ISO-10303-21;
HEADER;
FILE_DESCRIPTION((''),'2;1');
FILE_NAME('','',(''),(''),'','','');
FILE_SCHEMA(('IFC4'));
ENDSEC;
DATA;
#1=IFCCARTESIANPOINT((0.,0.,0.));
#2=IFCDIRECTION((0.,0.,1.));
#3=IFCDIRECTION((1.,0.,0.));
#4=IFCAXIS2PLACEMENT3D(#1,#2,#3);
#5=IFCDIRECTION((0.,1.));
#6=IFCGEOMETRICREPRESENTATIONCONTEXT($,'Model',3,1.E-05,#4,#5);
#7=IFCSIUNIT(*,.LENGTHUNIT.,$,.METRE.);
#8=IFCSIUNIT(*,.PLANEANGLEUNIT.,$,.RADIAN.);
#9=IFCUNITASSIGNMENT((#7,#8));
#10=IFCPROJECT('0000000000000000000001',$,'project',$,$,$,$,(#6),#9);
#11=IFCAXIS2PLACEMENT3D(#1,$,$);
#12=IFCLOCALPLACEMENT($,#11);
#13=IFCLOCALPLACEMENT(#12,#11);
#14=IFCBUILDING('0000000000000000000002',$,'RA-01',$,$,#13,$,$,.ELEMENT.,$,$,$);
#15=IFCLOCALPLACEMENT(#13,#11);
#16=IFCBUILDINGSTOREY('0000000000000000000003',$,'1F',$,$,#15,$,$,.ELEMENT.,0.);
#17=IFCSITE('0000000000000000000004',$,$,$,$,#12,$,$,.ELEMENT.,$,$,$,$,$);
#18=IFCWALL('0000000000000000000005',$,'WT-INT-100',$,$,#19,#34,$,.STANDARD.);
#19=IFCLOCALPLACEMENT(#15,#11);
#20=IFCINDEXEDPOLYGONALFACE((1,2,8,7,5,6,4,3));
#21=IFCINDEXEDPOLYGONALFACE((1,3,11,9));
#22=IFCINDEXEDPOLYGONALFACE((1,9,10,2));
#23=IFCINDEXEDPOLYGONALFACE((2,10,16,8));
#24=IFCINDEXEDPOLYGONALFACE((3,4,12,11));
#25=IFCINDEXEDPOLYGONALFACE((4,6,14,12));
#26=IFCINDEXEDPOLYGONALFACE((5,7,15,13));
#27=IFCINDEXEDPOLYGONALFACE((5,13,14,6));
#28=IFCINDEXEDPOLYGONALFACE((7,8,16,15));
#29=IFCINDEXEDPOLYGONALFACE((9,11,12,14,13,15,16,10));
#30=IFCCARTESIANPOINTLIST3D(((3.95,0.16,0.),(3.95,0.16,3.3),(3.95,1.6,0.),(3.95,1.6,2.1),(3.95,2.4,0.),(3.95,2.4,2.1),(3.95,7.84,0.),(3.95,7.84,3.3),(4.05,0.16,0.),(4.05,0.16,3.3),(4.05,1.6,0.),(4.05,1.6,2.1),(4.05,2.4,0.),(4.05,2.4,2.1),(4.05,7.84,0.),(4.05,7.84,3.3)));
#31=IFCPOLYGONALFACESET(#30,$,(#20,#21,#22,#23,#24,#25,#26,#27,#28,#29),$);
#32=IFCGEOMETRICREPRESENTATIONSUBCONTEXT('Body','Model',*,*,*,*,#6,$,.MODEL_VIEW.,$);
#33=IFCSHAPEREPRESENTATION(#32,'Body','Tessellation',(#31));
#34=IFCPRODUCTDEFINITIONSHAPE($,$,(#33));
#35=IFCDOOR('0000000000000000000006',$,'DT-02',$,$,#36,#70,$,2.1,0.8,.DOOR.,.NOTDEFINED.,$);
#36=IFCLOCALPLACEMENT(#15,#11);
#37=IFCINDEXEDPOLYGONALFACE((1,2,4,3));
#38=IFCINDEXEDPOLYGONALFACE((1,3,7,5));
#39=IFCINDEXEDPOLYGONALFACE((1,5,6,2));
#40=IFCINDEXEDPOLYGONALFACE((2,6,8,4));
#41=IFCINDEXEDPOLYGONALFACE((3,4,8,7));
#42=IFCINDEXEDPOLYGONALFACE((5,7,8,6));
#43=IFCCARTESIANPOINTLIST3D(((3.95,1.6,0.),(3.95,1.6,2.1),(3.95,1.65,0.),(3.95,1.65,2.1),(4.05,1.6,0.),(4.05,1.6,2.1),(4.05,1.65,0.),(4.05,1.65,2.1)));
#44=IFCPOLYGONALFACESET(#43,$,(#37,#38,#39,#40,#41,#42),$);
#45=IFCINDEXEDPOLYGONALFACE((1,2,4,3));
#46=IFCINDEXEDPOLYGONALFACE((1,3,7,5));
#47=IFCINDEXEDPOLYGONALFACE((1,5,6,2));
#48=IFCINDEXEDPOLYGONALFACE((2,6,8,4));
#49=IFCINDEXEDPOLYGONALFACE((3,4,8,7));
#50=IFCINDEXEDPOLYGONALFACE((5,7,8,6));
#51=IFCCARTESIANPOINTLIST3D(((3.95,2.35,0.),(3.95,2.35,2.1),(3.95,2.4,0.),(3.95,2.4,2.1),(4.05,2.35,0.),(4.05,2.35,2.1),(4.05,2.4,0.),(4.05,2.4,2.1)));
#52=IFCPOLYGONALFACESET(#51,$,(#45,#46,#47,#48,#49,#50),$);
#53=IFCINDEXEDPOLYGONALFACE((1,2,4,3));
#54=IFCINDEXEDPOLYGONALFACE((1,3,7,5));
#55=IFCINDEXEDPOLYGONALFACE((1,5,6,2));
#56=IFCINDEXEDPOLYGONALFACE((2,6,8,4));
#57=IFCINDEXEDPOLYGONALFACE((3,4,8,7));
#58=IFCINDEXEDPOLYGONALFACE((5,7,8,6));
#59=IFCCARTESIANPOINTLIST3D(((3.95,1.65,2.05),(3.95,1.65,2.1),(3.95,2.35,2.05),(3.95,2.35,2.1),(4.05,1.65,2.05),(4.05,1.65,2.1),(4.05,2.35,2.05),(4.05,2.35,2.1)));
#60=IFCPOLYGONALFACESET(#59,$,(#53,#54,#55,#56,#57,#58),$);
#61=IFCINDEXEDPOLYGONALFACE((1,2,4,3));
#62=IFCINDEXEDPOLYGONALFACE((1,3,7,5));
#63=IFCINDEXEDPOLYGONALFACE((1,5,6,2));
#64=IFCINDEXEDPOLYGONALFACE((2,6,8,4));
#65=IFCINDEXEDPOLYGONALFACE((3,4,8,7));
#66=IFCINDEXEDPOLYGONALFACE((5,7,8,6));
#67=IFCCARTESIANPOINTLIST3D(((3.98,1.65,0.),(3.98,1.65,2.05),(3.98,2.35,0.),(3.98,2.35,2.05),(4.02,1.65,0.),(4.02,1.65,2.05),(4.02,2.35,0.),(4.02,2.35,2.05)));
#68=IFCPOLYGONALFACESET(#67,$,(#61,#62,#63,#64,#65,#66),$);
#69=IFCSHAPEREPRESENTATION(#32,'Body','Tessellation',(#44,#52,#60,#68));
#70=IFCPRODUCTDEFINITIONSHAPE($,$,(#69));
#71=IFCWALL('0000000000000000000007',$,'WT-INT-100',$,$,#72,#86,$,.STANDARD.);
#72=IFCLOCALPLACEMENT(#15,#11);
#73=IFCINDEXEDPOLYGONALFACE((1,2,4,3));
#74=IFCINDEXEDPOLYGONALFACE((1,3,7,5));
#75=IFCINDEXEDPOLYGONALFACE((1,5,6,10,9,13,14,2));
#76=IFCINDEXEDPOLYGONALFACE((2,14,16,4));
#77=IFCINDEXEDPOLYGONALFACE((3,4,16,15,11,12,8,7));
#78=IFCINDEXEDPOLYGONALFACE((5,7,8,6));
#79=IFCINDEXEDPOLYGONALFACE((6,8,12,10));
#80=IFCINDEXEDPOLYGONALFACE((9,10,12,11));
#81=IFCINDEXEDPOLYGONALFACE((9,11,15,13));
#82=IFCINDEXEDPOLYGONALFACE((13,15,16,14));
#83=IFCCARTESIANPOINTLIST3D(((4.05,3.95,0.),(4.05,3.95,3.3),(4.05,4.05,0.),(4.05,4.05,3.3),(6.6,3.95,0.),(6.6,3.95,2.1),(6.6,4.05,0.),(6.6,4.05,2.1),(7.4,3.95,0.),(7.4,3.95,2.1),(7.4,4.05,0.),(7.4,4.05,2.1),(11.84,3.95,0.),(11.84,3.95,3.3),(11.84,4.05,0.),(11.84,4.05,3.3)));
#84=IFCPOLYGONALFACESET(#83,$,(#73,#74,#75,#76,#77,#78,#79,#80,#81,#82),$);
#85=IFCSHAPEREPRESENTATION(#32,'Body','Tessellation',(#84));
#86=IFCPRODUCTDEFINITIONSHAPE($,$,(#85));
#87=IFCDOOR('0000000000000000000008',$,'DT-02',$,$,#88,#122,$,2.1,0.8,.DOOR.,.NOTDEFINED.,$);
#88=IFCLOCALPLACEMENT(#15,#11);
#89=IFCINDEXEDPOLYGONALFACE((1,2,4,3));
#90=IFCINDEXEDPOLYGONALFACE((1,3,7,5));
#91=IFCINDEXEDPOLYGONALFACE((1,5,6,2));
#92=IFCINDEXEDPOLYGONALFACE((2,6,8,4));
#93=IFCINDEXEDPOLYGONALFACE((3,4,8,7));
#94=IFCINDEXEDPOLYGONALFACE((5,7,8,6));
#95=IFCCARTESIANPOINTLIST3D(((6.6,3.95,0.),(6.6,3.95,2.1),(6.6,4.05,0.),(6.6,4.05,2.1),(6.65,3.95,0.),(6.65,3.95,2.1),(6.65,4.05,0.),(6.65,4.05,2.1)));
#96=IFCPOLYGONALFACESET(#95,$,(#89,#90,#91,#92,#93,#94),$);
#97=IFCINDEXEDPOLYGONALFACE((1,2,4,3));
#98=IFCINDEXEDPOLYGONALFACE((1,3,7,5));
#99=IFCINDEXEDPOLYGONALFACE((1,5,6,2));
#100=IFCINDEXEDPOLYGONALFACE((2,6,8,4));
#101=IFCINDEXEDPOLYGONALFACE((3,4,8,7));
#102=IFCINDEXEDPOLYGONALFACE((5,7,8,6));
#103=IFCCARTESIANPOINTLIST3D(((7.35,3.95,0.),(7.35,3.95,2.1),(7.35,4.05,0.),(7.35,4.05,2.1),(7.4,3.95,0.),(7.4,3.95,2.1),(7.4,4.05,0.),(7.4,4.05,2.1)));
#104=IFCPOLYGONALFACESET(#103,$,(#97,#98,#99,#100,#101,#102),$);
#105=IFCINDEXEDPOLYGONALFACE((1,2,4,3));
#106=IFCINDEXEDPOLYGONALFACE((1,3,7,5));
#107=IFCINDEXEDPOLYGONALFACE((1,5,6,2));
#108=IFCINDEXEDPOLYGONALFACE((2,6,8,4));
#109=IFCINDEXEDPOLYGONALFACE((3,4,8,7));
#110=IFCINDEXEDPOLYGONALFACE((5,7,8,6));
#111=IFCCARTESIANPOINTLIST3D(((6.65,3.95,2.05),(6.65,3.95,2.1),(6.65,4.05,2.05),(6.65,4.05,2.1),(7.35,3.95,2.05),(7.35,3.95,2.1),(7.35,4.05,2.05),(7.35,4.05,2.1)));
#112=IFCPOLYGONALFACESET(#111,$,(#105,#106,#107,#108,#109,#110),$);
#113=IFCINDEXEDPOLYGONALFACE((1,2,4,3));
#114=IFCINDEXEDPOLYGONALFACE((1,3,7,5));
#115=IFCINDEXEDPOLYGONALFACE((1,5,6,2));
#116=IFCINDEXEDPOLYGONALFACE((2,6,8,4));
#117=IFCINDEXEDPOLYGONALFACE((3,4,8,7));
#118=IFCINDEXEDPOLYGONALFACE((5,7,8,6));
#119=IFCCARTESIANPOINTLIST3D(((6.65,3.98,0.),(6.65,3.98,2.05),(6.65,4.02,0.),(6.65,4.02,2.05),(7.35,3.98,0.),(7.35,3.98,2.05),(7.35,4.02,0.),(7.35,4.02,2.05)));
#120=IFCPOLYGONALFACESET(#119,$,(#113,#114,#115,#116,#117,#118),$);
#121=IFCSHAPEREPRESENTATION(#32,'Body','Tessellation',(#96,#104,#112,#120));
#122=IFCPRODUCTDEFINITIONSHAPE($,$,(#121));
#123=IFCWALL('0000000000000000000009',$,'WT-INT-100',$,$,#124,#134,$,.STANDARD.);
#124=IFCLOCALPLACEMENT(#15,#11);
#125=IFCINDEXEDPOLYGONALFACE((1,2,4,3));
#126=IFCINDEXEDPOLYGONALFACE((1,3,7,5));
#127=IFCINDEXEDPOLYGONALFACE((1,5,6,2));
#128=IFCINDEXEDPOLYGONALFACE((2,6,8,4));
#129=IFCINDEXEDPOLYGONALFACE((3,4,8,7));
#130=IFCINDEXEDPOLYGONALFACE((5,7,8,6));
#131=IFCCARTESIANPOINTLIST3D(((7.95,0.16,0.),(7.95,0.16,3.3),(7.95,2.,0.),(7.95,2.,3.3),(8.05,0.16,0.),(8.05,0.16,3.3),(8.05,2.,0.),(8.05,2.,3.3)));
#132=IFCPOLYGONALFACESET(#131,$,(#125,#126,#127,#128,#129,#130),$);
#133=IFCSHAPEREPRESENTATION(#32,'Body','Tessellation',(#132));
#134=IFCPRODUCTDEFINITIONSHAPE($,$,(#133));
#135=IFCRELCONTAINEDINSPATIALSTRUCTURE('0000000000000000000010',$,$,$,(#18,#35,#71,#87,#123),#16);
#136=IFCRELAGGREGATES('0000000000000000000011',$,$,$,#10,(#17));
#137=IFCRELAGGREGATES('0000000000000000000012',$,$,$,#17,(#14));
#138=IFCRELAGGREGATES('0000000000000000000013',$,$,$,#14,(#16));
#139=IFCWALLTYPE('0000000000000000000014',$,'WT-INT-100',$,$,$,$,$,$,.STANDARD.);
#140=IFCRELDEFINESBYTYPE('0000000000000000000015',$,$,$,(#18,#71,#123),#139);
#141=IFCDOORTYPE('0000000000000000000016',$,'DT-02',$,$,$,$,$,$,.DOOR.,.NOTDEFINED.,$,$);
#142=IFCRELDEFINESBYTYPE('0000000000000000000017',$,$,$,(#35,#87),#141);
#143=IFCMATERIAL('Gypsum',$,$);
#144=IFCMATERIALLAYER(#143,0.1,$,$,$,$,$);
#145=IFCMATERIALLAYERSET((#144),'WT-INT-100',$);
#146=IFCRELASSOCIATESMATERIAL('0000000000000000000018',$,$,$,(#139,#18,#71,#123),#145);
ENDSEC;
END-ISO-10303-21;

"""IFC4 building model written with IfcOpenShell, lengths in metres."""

from ifc_helpers import new_model, si_unit, direction, frame, frame_2d, origin, origin_with_axes, place, context, subcontext, project, spatial, polyline, rectangle, outline, extrude, material, layer, layer_set, layer_usage, type_object, element, fill, save


model = new_model("IFC4")

# Units and contexts
model_context = context("Model", 3, precision=1e-05, world=origin_with_axes(), true_north=direction((0.0, 1.0)))
body_context = subcontext(model_context, "Body", "Model", "MODEL_VIEW")
ifc_project = project(units=[si_unit("LENGTHUNIT", "METRE"), si_unit("PLANEANGLEUNIT", "RADIAN")], contexts=[model_context])

# Site, building, storey
site_placement = place(None, origin())
site = spatial("IfcSite", under=ifc_project, at=site_placement, CompositionType="ELEMENT")
building_placement = place(site_placement, origin())
building = spatial("IfcBuilding", under=site, at=building_placement, Name="RA-01", CompositionType="ELEMENT")
storey_placement = place(building_placement, origin())
storey = spatial("IfcBuildingStorey", under=building, at=storey_placement, Name="1F", CompositionType="ELEMENT", Elevation=0.0)

# Walls, openings, doors
ifc_material_1 = material(Name="Gypsum")
ifc_layer_1 = layer(ifc_material_1, 0.1)
ifc_layer_set_1 = layer_set([ifc_layer_1], Name="WT-INT-100")
ifc_layer_usage_1 = layer_usage(ifc_layer_set_1, "AXIS2", "NEGATIVE", 0.05)
wall_type_1 = type_object("IfcWallType", Name="WT-INT-100", PredefinedType="STANDARD", material=ifc_layer_set_1)
wall_1_placement = place(storey_placement, frame((4.0, 0.16, 0.0), z_axis=(0.0, 0.0, 1.0), x_axis=(0.0, 1.0, 0.0)))
wall_1 = element("IfcWall", 1, at=wall_1_placement, inside=storey, type_object=wall_type_1, material=ifc_layer_usage_1, Name="WT-INT-100", PredefinedType="STANDARD", context=body_context, shape_type="SweptSolid", body=[
    extrude(outline(polyline([(0.0, -0.05), (7.68, -0.05), (7.68, 0.05), (0.0, 0.05), (0.0, -0.05)])), origin(), (0.0, 0.0, 1.0), 3.3),
])
opening_1_placement = place(wall_1_placement, frame((1.44, 0.0, 0.0)))
opening_1 = element("IfcOpeningElement", 2, at=opening_1_placement, cuts=wall_1, PredefinedType="OPENING", context=body_context, shape_type="SweptSolid", body=[
    extrude(rectangle(XDim=0.8, YDim=0.2, at=frame_2d((0.4, 0.0))), origin(), (0.0, 0.0, 1.0), 2.1),
])
door_type_1 = type_object("IfcDoorType", Name="DT-02", OperationType="NOTDEFINED", PredefinedType="DOOR")
door_1_placement = place(opening_1_placement, origin())
door_1 = element("IfcDoor", 3, at=door_1_placement, inside=storey, type_object=door_type_1, Name="DT-02", OperationType="NOTDEFINED", OverallHeight=2.1, OverallWidth=0.8, PredefinedType="DOOR", context=body_context, shape_type="SweptSolid", body=[
    extrude(outline(polyline([(0.0, -0.05), (0.05, -0.05), (0.05, 0.05), (0.0, 0.05), (0.0, -0.05)])), origin(), (0.0, 0.0, 1.0), 2.1),
    extrude(outline(polyline([(0.75, -0.05), (0.8, -0.05), (0.8, 0.05), (0.75, 0.05), (0.75, -0.05)])), origin(), (0.0, 0.0, 1.0), 2.1),
    extrude(outline(polyline([(0.05, -0.05), (0.75, -0.05), (0.75, 0.05), (0.05, 0.05), (0.05, -0.05)])), frame((0.0, 0.0, 2.05)), (0.0, 0.0, 1.0), 0.05),
    extrude(outline(polyline([(0.05, -0.02), (0.75, -0.02), (0.75, 0.02), (0.05, 0.02), (0.05, -0.02)])), origin(), (0.0, 0.0, 1.0), 2.05),
])
fill(opening_1, door_1)
wall_2_placement = place(storey_placement, frame((4.05, 4.0, 0.0)))
wall_2 = element("IfcWall", 4, at=wall_2_placement, inside=storey, type_object=wall_type_1, material=ifc_layer_usage_1, Name="WT-INT-100", PredefinedType="STANDARD", context=body_context, shape_type="SweptSolid", body=[
    extrude(outline(polyline([(0.0, -0.05), (7.79, -0.05), (7.79, 0.05), (0.0, 0.05), (0.0, -0.05)])), origin(), (0.0, 0.0, 1.0), 3.3),
])
opening_2_placement = place(wall_2_placement, frame((2.55, 0.0, 0.0)))
opening_2 = element("IfcOpeningElement", 5, at=opening_2_placement, cuts=wall_2, PredefinedType="OPENING", context=body_context, shape_type="SweptSolid", body=[
    extrude(rectangle(XDim=0.8, YDim=0.2, at=frame_2d((0.4, 0.0))), origin(), (0.0, 0.0, 1.0), 2.1),
])
door_2_placement = place(opening_2_placement, origin())
door_2 = element("IfcDoor", 6, at=door_2_placement, inside=storey, type_object=door_type_1, Name="DT-02", OperationType="NOTDEFINED", OverallHeight=2.1, OverallWidth=0.8, PredefinedType="DOOR", context=body_context, shape_type="SweptSolid", body=[
    extrude(outline(polyline([(0.0, -0.05), (0.05, -0.05), (0.05, 0.05), (0.0, 0.05), (0.0, -0.05)])), origin(), (0.0, 0.0, 1.0), 2.1),
    extrude(outline(polyline([(0.75, -0.05), (0.8, -0.05), (0.8, 0.05), (0.75, 0.05), (0.75, -0.05)])), origin(), (0.0, 0.0, 1.0), 2.1),
    extrude(outline(polyline([(0.05, -0.05), (0.75, -0.05), (0.75, 0.05), (0.05, 0.05), (0.05, -0.05)])), frame((0.0, 0.0, 2.05)), (0.0, 0.0, 1.0), 0.05),
    extrude(outline(polyline([(0.05, -0.02), (0.75, -0.02), (0.75, 0.02), (0.05, 0.02), (0.05, -0.02)])), origin(), (0.0, 0.0, 1.0), 2.05),
])
fill(opening_2, door_2)

# Wall
wall_3_placement = place(storey_placement, frame((8.0, 0.16, 0.0), z_axis=(0.0, 0.0, 1.0), x_axis=(0.0, 1.0, 0.0)))
element("IfcWall", 7, at=wall_3_placement, inside=storey, type_object=wall_type_1, material=ifc_layer_usage_1, Name="WT-INT-100", PredefinedType="STANDARD", context=body_context, shape_type="SweptSolid", body=[
    extrude(outline(polyline([(0.0, -0.05), (1.84, -0.05), (1.84, 0.05), (0.0, 0.05), (0.0, -0.05)])), origin(), (0.0, 0.0, 1.0), 3.3),
])

save(model, "model.ifc")
